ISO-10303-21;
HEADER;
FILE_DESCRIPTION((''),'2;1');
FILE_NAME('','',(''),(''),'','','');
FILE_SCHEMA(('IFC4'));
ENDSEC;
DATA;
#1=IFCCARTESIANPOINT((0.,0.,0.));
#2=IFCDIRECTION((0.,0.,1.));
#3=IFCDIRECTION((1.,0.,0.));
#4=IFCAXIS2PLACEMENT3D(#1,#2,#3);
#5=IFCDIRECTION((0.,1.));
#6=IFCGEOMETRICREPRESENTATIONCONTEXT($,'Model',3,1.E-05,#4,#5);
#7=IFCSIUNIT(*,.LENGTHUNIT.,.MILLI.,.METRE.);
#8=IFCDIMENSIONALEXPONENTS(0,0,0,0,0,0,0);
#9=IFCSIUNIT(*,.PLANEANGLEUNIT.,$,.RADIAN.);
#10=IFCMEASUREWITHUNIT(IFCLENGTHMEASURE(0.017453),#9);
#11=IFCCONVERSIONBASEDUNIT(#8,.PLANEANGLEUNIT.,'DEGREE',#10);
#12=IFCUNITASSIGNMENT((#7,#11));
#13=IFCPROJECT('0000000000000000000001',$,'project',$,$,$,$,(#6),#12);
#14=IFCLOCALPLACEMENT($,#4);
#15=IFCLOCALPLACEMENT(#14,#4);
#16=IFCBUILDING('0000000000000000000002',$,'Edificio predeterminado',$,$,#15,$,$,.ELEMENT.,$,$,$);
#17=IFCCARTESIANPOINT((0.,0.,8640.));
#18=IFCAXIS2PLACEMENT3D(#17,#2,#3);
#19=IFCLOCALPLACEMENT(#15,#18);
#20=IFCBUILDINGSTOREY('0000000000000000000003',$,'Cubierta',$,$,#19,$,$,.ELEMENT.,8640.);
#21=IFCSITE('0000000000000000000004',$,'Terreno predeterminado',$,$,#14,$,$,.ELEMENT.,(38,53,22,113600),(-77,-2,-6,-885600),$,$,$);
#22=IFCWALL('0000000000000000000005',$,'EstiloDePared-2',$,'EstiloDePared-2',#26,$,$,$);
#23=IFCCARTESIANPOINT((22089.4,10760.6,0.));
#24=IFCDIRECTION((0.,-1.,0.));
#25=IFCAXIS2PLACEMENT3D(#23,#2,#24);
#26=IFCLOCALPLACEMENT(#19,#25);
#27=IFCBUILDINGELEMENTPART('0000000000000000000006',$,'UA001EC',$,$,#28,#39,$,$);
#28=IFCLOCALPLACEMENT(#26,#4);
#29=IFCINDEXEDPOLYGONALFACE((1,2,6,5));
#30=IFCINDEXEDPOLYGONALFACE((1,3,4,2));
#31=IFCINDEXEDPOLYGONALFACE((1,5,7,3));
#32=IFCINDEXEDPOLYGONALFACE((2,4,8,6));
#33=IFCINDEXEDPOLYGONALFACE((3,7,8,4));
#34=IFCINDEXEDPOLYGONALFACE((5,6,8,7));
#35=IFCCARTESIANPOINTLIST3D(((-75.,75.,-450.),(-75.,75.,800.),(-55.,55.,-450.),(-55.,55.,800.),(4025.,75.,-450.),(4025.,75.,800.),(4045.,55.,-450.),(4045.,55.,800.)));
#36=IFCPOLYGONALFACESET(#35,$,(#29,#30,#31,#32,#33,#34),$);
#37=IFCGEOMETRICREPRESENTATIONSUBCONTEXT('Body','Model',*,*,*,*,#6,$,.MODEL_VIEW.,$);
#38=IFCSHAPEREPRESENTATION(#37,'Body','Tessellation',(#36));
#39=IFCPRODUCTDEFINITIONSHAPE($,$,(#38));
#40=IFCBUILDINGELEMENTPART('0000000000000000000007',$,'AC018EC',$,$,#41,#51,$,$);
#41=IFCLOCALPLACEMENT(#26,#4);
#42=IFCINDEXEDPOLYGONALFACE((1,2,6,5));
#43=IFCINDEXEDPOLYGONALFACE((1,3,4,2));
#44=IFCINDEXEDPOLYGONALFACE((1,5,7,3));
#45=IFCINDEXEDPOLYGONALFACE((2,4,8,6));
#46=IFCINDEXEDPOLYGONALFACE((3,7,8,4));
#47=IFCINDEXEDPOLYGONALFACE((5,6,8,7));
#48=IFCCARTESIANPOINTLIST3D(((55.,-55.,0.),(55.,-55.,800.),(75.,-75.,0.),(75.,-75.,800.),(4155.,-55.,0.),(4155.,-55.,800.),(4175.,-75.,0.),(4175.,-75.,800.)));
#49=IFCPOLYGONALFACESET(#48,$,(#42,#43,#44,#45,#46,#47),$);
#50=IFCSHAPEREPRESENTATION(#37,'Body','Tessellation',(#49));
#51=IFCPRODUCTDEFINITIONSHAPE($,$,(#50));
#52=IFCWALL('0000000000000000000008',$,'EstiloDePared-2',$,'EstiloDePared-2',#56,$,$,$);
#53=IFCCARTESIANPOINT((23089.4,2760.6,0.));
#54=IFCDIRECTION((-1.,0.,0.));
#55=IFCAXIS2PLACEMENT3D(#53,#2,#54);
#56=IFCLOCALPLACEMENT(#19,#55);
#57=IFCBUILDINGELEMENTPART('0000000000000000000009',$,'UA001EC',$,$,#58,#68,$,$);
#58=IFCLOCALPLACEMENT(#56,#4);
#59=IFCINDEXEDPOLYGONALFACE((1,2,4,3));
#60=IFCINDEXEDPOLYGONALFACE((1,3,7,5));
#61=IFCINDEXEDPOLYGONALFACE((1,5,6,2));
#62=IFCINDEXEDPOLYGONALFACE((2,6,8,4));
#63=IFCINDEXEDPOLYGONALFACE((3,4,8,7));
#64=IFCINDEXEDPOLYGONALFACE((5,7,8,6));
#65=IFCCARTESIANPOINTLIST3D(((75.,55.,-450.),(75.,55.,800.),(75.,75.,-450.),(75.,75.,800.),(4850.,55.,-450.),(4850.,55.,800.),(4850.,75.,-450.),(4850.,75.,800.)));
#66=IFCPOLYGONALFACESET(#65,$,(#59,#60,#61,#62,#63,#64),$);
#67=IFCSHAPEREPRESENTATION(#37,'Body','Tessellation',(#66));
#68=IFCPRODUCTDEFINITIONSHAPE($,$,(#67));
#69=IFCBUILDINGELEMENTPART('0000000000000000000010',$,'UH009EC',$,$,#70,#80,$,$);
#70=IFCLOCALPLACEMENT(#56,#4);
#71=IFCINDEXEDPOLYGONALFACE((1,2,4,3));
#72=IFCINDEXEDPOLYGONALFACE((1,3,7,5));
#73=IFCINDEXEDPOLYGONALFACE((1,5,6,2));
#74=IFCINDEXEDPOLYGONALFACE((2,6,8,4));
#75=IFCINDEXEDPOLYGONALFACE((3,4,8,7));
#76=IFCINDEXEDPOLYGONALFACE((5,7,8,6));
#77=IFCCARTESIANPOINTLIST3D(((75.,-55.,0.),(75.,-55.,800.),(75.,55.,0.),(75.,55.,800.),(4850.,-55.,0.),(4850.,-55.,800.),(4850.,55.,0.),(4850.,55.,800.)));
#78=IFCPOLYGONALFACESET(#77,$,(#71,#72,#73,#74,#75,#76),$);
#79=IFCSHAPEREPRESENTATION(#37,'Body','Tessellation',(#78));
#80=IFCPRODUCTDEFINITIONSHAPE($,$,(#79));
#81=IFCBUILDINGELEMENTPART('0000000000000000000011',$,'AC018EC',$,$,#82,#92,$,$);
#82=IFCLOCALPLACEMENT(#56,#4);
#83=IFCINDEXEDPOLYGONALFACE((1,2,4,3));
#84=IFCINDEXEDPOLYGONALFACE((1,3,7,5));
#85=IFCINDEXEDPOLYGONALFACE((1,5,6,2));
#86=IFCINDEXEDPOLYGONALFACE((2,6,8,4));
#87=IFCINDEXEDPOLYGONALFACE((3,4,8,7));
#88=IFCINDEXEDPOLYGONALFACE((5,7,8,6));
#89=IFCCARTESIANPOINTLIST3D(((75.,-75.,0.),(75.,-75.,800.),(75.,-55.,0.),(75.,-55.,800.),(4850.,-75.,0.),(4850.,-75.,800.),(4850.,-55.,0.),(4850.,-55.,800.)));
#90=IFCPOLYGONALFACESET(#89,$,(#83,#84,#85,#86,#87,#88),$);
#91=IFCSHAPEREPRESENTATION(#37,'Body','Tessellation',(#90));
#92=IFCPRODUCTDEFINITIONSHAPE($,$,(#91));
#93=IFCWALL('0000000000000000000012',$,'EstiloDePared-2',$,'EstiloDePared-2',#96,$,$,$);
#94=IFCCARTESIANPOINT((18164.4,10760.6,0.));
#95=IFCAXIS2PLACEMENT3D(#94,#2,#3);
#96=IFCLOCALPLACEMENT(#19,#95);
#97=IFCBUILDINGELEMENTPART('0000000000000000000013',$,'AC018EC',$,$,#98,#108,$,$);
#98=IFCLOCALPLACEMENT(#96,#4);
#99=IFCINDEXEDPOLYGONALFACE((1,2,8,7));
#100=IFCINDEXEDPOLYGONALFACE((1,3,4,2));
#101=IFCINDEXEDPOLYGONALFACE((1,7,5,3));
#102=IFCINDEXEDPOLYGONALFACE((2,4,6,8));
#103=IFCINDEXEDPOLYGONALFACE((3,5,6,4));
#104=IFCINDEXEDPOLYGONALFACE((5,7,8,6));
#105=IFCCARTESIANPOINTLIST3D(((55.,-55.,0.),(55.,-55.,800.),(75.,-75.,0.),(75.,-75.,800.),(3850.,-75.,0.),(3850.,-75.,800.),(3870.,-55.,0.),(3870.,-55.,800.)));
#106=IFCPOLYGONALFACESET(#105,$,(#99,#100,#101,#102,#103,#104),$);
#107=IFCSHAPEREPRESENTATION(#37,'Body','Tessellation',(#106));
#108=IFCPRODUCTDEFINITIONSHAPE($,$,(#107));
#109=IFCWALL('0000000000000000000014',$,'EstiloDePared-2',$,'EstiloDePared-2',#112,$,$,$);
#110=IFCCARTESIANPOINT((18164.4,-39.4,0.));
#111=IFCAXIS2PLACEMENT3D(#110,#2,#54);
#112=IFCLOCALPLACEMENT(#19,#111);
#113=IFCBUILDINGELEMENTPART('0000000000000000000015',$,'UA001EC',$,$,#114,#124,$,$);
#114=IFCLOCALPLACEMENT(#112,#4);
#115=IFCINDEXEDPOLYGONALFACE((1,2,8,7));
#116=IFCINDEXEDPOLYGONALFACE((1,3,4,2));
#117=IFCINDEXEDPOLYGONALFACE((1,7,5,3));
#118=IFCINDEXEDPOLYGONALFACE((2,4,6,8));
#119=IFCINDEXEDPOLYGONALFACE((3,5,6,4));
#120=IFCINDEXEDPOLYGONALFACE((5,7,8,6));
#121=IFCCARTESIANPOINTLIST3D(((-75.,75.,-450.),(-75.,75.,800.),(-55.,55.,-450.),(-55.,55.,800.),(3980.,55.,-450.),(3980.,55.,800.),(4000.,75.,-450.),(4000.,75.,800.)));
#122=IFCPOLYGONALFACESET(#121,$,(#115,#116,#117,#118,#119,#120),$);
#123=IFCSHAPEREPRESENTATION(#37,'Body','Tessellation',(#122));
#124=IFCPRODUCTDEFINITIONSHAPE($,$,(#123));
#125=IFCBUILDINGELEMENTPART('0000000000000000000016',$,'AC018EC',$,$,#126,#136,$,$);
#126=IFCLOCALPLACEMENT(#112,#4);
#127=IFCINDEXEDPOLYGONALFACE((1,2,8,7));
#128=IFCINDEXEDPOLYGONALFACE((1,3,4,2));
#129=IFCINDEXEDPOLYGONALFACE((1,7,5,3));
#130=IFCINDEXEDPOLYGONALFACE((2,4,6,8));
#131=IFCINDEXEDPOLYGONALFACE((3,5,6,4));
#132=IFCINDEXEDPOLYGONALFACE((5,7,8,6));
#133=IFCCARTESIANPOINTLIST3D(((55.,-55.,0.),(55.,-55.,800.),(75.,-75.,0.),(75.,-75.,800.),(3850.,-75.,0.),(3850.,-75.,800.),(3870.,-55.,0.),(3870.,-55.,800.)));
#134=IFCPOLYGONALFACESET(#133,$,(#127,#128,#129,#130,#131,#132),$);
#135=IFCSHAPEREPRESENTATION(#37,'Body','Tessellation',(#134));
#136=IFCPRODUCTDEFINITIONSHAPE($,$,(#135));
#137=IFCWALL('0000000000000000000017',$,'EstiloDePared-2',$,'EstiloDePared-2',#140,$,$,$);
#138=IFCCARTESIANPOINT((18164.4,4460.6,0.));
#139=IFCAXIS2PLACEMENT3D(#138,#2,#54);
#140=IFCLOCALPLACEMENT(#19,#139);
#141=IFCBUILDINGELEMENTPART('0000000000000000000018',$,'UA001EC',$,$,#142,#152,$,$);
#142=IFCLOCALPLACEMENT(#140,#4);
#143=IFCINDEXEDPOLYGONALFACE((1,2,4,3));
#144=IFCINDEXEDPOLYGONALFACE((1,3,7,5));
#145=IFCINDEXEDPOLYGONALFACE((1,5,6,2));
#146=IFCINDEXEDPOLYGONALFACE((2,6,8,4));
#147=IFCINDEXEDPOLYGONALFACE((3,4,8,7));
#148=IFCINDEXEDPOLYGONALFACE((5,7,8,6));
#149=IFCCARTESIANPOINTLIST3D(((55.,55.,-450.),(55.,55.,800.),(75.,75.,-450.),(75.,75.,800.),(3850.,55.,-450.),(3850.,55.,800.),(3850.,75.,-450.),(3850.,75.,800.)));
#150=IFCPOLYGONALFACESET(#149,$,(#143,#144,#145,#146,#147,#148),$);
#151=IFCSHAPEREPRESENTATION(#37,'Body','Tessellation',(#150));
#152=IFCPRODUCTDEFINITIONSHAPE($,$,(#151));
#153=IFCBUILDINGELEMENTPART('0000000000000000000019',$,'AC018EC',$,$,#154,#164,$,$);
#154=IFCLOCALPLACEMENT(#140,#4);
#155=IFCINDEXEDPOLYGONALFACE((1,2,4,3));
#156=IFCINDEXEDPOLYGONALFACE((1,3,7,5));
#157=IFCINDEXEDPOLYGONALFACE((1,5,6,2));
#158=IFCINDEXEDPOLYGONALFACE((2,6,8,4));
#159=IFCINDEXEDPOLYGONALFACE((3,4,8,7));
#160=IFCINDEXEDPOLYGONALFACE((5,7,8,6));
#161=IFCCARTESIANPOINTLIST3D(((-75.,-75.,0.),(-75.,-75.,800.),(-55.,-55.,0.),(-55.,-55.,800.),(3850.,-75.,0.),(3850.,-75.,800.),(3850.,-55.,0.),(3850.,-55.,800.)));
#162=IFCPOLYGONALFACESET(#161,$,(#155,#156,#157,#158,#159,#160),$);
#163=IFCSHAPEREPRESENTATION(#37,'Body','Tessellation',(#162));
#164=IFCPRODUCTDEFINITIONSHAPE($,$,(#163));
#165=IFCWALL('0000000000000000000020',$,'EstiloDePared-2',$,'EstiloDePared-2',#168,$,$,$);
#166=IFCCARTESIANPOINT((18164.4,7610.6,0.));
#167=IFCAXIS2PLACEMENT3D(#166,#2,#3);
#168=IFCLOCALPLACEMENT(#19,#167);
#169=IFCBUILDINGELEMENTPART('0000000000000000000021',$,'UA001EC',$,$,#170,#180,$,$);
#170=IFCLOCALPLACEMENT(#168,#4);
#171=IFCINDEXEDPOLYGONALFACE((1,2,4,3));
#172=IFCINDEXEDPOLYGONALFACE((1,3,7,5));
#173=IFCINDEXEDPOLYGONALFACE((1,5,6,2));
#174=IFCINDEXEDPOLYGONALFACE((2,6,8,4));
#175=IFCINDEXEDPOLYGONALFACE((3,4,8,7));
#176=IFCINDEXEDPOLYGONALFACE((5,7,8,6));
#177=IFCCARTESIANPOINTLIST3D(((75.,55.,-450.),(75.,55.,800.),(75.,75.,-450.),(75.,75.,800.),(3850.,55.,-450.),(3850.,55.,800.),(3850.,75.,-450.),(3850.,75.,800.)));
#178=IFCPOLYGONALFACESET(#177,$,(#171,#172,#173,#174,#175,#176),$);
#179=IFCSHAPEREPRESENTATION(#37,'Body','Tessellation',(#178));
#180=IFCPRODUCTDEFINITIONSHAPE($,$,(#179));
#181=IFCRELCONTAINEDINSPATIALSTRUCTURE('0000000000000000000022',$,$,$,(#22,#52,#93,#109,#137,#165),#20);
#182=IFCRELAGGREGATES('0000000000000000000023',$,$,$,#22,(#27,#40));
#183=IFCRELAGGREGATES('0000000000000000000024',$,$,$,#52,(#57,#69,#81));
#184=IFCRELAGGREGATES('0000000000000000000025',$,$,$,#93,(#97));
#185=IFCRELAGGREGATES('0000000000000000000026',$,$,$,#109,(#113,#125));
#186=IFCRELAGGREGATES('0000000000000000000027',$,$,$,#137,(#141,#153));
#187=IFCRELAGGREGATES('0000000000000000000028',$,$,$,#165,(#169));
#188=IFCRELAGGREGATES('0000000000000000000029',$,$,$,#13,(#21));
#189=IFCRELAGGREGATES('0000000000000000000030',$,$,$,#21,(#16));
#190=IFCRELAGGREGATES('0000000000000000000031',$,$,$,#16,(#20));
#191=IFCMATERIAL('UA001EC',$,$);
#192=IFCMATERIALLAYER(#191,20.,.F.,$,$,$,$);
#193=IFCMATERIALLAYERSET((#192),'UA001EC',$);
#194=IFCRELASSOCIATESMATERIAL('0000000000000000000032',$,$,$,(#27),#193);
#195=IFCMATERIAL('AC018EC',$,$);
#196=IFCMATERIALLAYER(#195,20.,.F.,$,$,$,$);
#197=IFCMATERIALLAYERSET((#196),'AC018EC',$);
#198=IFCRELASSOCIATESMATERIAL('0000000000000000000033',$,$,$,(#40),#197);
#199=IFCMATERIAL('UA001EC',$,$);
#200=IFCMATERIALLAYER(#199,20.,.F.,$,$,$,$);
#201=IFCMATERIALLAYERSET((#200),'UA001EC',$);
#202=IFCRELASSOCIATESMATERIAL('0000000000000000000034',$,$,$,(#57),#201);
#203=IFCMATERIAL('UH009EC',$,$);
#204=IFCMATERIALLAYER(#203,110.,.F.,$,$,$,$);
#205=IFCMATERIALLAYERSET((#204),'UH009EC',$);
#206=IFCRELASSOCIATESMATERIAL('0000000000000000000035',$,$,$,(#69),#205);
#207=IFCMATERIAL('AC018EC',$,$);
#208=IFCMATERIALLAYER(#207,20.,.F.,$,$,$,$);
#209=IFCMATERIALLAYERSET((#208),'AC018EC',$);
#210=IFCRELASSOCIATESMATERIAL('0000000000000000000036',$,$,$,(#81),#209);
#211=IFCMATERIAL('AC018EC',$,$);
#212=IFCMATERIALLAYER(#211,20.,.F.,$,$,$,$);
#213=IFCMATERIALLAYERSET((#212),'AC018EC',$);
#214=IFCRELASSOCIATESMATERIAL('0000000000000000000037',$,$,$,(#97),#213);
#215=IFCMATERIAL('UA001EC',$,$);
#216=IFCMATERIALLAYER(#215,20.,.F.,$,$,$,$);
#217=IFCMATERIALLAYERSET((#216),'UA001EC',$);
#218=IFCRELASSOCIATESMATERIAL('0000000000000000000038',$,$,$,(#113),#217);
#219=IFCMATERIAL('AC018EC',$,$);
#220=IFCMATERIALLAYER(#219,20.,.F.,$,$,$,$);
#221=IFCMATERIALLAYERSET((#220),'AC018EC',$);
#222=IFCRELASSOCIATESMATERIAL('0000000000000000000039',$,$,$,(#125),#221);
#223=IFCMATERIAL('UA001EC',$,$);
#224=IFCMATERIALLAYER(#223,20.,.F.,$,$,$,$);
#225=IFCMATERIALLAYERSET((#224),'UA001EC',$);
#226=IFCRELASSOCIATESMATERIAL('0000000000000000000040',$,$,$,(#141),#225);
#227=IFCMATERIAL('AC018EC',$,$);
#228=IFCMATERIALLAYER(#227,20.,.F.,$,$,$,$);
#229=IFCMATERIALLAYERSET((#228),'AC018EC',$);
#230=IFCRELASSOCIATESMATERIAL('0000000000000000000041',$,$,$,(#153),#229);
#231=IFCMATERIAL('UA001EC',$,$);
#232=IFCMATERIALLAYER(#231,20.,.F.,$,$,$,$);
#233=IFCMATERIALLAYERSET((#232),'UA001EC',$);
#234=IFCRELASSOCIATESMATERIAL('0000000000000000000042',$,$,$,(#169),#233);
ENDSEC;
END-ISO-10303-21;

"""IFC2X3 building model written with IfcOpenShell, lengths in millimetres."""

from ifc_helpers import new_model, entity, si_unit, converted_unit, direction, frame, origin_with_axes, place, context, subcontext, project, spatial, polyline, outline, extrude, material, layer, layer_set, layer_usage, element, aggregate, save


model = new_model("IFC2X3")

# Units and contexts
model_context = context("Model", 3, precision=1e-05, world=origin_with_axes(), true_north=direction((0.0, 1.0)))
body_context = subcontext(model_context, "Body", "Model", "MODEL_VIEW")
ifc_project = project(units=[si_unit("LENGTHUNIT", "METRE", prefix="MILLI"), converted_unit("PLANEANGLEUNIT", "DEGREE", entity("IfcLengthMeasure", 0.017453), si_unit("PLANEANGLEUNIT", "RADIAN"), dimensions=[0, 0, 0, 0, 0, 0, 0])], contexts=[model_context])

# Site, building, storey
site_placement = place(None, origin_with_axes())
site = spatial("IfcSite", under=ifc_project, at=site_placement, Name="Terreno predeterminado", CompositionType="ELEMENT", RefLatitude=(38, 53, 22, 113600), RefLongitude=(-77, -2, -6, -885600))
building_placement = place(site_placement, origin_with_axes())
building = spatial("IfcBuilding", under=site, at=building_placement, Name="Edificio predeterminado", CompositionType="ELEMENT")
storey_placement = place(building_placement, frame((0.0, 0.0, 8640.0), z_axis=(0.0, 0.0, 1.0), x_axis=(1.0, 0.0, 0.0)))
storey = spatial("IfcBuildingStorey", under=building, at=storey_placement, Name="Cubierta", CompositionType="ELEMENT", Elevation=8640.0)

# Walls, building element parts
wall_1_placement = place(storey_placement, frame((22089.4, 10760.6, 0.0), z_axis=(0.0, 0.0, 1.0), x_axis=(0.0, -1.0, 0.0)))
wall_1 = element("IfcWall", 1, at=wall_1_placement, inside=storey, Name="EstiloDePared-2", ObjectType="EstiloDePared-2")
ifc_material_1 = material(Name="UA001EC")
ifc_layer_1 = layer(ifc_material_1, 20.0, ventilated=False)
ifc_layer_set_1 = layer_set([ifc_layer_1], Name="UA001EC")
ifc_layer_usage_1 = layer_usage(ifc_layer_set_1, "AXIS2", "NEGATIVE", -75.0)
building_element_part_1_placement = place(wall_1_placement, origin_with_axes())
building_element_part_1 = element("IfcBuildingElementPart", 2, at=building_element_part_1_placement, material=ifc_layer_usage_1, Name="UA001EC", context=body_context, shape_type="SweptSolid", body=[
    extrude(outline(polyline([(4025.0, 75.0), (4045.0, 55.0), (-55.0, 55.0), (-75.0, 75.0), (4025.0, 75.0)])), frame((0.0, 0.0, -450.0), z_axis=(0.0, 0.0, 1.0), x_axis=(1.0, 0.0, 0.0)), (0.0, 0.0, 1.0), 1250.0),
])
ifc_material_2 = material(Name="AC018EC")
ifc_layer_2 = layer(ifc_material_2, 20.0, ventilated=False)
ifc_layer_set_2 = layer_set([ifc_layer_2], Name="AC018EC")
ifc_layer_usage_2 = layer_usage(ifc_layer_set_2, "AXIS2", "NEGATIVE", 55.0)
building_element_part_2_placement = place(wall_1_placement, origin_with_axes())
building_element_part_2 = element("IfcBuildingElementPart", 3, at=building_element_part_2_placement, material=ifc_layer_usage_2, Name="AC018EC", context=body_context, shape_type="SweptSolid", body=[
    extrude(outline(polyline([(4155.0, -55.0), (4175.0, -75.0), (75.0, -75.0), (55.0, -55.0), (4155.0, -55.0)])), origin_with_axes(), (0.0, 0.0, 1.0), 800.0),
])
aggregate(wall_1, [building_element_part_1, building_element_part_2])
wall_2_placement = place(storey_placement, frame((23089.4, 2760.6, 0.0), z_axis=(0.0, 0.0, 1.0), x_axis=(-1.0, 0.0, 0.0)))
wall_2 = element("IfcWall", 4, at=wall_2_placement, inside=storey, Name="EstiloDePared-2", ObjectType="EstiloDePared-2")
ifc_material_3 = material(Name="UA001EC")
ifc_layer_3 = layer(ifc_material_3, 20.0, ventilated=False)
ifc_layer_set_3 = layer_set([ifc_layer_3], Name="UA001EC")
ifc_layer_usage_3 = layer_usage(ifc_layer_set_3, "AXIS2", "NEGATIVE", -75.0)
building_element_part_3_placement = place(wall_2_placement, origin_with_axes())
building_element_part_3 = element("IfcBuildingElementPart", 5, at=building_element_part_3_placement, material=ifc_layer_usage_3, Name="UA001EC", context=body_context, shape_type="SweptSolid", body=[
    extrude(outline(polyline([(4850.0, 75.0), (4850.0, 55.0), (75.0, 55.0), (75.0, 75.0), (4850.0, 75.0)])), frame((0.0, 0.0, -450.0), z_axis=(0.0, 0.0, 1.0), x_axis=(1.0, 0.0, 0.0)), (0.0, 0.0, 1.0), 1250.0),
])
ifc_material_4 = material(Name="UH009EC")
ifc_layer_4 = layer(ifc_material_4, 110.0, ventilated=False)
ifc_layer_set_4 = layer_set([ifc_layer_4], Name="UH009EC")
ifc_layer_usage_4 = layer_usage(ifc_layer_set_4, "AXIS2", "NEGATIVE", -55.0)
building_element_part_4_placement = place(wall_2_placement, origin_with_axes())
building_element_part_4 = element("IfcBuildingElementPart", 6, at=building_element_part_4_placement, material=ifc_layer_usage_4, Name="UH009EC", context=body_context, shape_type="SweptSolid", body=[
    extrude(outline(polyline([(4850.0, 55.0), (4850.0, -55.0), (75.0, -55.0), (75.0, 55.0), (4850.0, 55.0)])), origin_with_axes(), (0.0, 0.0, 1.0), 800.0),
])
ifc_material_5 = material(Name="AC018EC")
ifc_layer_5 = layer(ifc_material_5, 20.0, ventilated=False)
ifc_layer_set_5 = layer_set([ifc_layer_5], Name="AC018EC")
ifc_layer_usage_5 = layer_usage(ifc_layer_set_5, "AXIS2", "NEGATIVE", 55.0)
building_element_part_5_placement = place(wall_2_placement, origin_with_axes())
building_element_part_5 = element("IfcBuildingElementPart", 7, at=building_element_part_5_placement, material=ifc_layer_usage_5, Name="AC018EC", context=body_context, shape_type="SweptSolid", body=[
    extrude(outline(polyline([(4850.0, -55.0), (4850.0, -75.0), (75.0, -75.0), (75.0, -55.0), (4850.0, -55.0)])), origin_with_axes(), (0.0, 0.0, 1.0), 800.0),
])
aggregate(wall_2, [building_element_part_3, building_element_part_4, building_element_part_5])

# Wall, building element part
wall_3_placement = place(storey_placement, frame((18164.4, 10760.6, 0.0), z_axis=(0.0, 0.0, 1.0), x_axis=(1.0, 0.0, 0.0)))
wall_3 = element("IfcWall", 8, at=wall_3_placement, inside=storey, Name="EstiloDePared-2", ObjectType="EstiloDePared-2")
ifc_material_6 = material(Name="AC018EC")
ifc_layer_6 = layer(ifc_material_6, 20.0, ventilated=False)
ifc_layer_set_6 = layer_set([ifc_layer_6], Name="AC018EC")
ifc_layer_usage_6 = layer_usage(ifc_layer_set_6, "AXIS2", "NEGATIVE", 55.0)
building_element_part_6_placement = place(wall_3_placement, origin_with_axes())
building_element_part_6 = element("IfcBuildingElementPart", 9, at=building_element_part_6_placement, material=ifc_layer_usage_6, Name="AC018EC", context=body_context, shape_type="SweptSolid", body=[
    extrude(outline(polyline([(3870.0, -55.0), (3850.0, -75.0), (75.0, -75.0), (55.0, -55.0), (3870.0, -55.0)])), origin_with_axes(), (0.0, 0.0, 1.0), 800.0),
])
aggregate(wall_3, [building_element_part_6])

# Walls, building element parts
wall_4_placement = place(storey_placement, frame((18164.4, -39.4, 0.0), z_axis=(0.0, 0.0, 1.0), x_axis=(-1.0, 0.0, 0.0)))
wall_4 = element("IfcWall", 10, at=wall_4_placement, inside=storey, Name="EstiloDePared-2", ObjectType="EstiloDePared-2")
ifc_material_7 = material(Name="UA001EC")
ifc_layer_7 = layer(ifc_material_7, 20.0, ventilated=False)
ifc_layer_set_7 = layer_set([ifc_layer_7], Name="UA001EC")
ifc_layer_usage_7 = layer_usage(ifc_layer_set_7, "AXIS2", "NEGATIVE", -75.0)
building_element_part_7_placement = place(wall_4_placement, origin_with_axes())
building_element_part_7 = element("IfcBuildingElementPart", 11, at=building_element_part_7_placement, material=ifc_layer_usage_7, Name="UA001EC", context=body_context, shape_type="SweptSolid", body=[
    extrude(outline(polyline([(4000.0, 75.0), (3980.0, 55.0), (-55.0, 55.0), (-75.0, 75.0), (4000.0, 75.0)])), frame((0.0, 0.0, -450.0), z_axis=(0.0, 0.0, 1.0), x_axis=(1.0, 0.0, 0.0)), (0.0, 0.0, 1.0), 1250.0),
])
ifc_material_8 = material(Name="AC018EC")
ifc_layer_8 = layer(ifc_material_8, 20.0, ventilated=False)
ifc_layer_set_8 = layer_set([ifc_layer_8], Name="AC018EC")
ifc_layer_usage_8 = layer_usage(ifc_layer_set_8, "AXIS2", "NEGATIVE", 55.0)
building_element_part_8_placement = place(wall_4_placement, origin_with_axes())
building_element_part_8 = element("IfcBuildingElementPart", 12, at=building_element_part_8_placement, material=ifc_layer_usage_8, Name="AC018EC", context=body_context, shape_type="SweptSolid", body=[
    extrude(outline(polyline([(3870.0, -55.0), (3850.0, -75.0), (75.0, -75.0), (55.0, -55.0), (3870.0, -55.0)])), origin_with_axes(), (0.0, 0.0, 1.0), 800.0),
])
aggregate(wall_4, [building_element_part_7, building_element_part_8])
wall_5_placement = place(storey_placement, frame((18164.4, 4460.6, 0.0), z_axis=(0.0, 0.0, 1.0), x_axis=(-1.0, 0.0, 0.0)))
wall_5 = element("IfcWall", 13, at=wall_5_placement, inside=storey, Name="EstiloDePared-2", ObjectType="EstiloDePared-2")
ifc_material_9 = material(Name="UA001EC")
ifc_layer_9 = layer(ifc_material_9, 20.0, ventilated=False)
ifc_layer_set_9 = layer_set([ifc_layer_9], Name="UA001EC")
ifc_layer_usage_9 = layer_usage(ifc_layer_set_9, "AXIS2", "NEGATIVE", -75.0)
building_element_part_9_placement = place(wall_5_placement, origin_with_axes())
building_element_part_9 = element("IfcBuildingElementPart", 14, at=building_element_part_9_placement, material=ifc_layer_usage_9, Name="UA001EC", context=body_context, shape_type="SweptSolid", body=[
    extrude(outline(polyline([(3850.0, 75.0), (3850.0, 55.0), (55.0, 55.0), (75.0, 75.0), (3850.0, 75.0)])), frame((0.0, 0.0, -450.0), z_axis=(0.0, 0.0, 1.0), x_axis=(1.0, 0.0, 0.0)), (0.0, 0.0, 1.0), 1250.0),
])
ifc_material_10 = material(Name="AC018EC")
ifc_layer_10 = layer(ifc_material_10, 20.0, ventilated=False)
ifc_layer_set_10 = layer_set([ifc_layer_10], Name="AC018EC")
ifc_layer_usage_10 = layer_usage(ifc_layer_set_10, "AXIS2", "NEGATIVE", 55.0)
building_element_part_10_placement = place(wall_5_placement, origin_with_axes())
building_element_part_10 = element("IfcBuildingElementPart", 15, at=building_element_part_10_placement, material=ifc_layer_usage_10, Name="AC018EC", context=body_context, shape_type="SweptSolid", body=[
    extrude(outline(polyline([(3850.0, -55.0), (3850.0, -75.0), (-75.0, -75.0), (-55.0, -55.0), (3850.0, -55.0)])), origin_with_axes(), (0.0, 0.0, 1.0), 800.0),
])
aggregate(wall_5, [building_element_part_9, building_element_part_10])
wall_6_placement = place(storey_placement, frame((18164.4, 7610.6, 0.0), z_axis=(0.0, 0.0, 1.0), x_axis=(1.0, 0.0, 0.0)))
wall_6 = element("IfcWall", 16, at=wall_6_placement, inside=storey, Name="EstiloDePared-2", ObjectType="EstiloDePared-2")
ifc_material_11 = material(Name="UA001EC")
ifc_layer_11 = layer(ifc_material_11, 20.0, ventilated=False)
ifc_layer_set_11 = layer_set([ifc_layer_11], Name="UA001EC")
ifc_layer_usage_11 = layer_usage(ifc_layer_set_11, "AXIS2", "NEGATIVE", -75.0)
building_element_part_11_placement = place(wall_6_placement, origin_with_axes())
building_element_part_11 = element("IfcBuildingElementPart", 17, at=building_element_part_11_placement, material=ifc_layer_usage_11, Name="UA001EC", context=body_context, shape_type="SweptSolid", body=[
    extrude(outline(polyline([(3850.0, 75.0), (3850.0, 55.0), (75.0, 55.0), (75.0, 75.0), (3850.0, 75.0)])), frame((0.0, 0.0, -450.0), z_axis=(0.0, 0.0, 1.0), x_axis=(1.0, 0.0, 0.0)), (0.0, 0.0, 1.0), 1250.0),
])
aggregate(wall_6, [building_element_part_11])

save(model, "model.ifc")
